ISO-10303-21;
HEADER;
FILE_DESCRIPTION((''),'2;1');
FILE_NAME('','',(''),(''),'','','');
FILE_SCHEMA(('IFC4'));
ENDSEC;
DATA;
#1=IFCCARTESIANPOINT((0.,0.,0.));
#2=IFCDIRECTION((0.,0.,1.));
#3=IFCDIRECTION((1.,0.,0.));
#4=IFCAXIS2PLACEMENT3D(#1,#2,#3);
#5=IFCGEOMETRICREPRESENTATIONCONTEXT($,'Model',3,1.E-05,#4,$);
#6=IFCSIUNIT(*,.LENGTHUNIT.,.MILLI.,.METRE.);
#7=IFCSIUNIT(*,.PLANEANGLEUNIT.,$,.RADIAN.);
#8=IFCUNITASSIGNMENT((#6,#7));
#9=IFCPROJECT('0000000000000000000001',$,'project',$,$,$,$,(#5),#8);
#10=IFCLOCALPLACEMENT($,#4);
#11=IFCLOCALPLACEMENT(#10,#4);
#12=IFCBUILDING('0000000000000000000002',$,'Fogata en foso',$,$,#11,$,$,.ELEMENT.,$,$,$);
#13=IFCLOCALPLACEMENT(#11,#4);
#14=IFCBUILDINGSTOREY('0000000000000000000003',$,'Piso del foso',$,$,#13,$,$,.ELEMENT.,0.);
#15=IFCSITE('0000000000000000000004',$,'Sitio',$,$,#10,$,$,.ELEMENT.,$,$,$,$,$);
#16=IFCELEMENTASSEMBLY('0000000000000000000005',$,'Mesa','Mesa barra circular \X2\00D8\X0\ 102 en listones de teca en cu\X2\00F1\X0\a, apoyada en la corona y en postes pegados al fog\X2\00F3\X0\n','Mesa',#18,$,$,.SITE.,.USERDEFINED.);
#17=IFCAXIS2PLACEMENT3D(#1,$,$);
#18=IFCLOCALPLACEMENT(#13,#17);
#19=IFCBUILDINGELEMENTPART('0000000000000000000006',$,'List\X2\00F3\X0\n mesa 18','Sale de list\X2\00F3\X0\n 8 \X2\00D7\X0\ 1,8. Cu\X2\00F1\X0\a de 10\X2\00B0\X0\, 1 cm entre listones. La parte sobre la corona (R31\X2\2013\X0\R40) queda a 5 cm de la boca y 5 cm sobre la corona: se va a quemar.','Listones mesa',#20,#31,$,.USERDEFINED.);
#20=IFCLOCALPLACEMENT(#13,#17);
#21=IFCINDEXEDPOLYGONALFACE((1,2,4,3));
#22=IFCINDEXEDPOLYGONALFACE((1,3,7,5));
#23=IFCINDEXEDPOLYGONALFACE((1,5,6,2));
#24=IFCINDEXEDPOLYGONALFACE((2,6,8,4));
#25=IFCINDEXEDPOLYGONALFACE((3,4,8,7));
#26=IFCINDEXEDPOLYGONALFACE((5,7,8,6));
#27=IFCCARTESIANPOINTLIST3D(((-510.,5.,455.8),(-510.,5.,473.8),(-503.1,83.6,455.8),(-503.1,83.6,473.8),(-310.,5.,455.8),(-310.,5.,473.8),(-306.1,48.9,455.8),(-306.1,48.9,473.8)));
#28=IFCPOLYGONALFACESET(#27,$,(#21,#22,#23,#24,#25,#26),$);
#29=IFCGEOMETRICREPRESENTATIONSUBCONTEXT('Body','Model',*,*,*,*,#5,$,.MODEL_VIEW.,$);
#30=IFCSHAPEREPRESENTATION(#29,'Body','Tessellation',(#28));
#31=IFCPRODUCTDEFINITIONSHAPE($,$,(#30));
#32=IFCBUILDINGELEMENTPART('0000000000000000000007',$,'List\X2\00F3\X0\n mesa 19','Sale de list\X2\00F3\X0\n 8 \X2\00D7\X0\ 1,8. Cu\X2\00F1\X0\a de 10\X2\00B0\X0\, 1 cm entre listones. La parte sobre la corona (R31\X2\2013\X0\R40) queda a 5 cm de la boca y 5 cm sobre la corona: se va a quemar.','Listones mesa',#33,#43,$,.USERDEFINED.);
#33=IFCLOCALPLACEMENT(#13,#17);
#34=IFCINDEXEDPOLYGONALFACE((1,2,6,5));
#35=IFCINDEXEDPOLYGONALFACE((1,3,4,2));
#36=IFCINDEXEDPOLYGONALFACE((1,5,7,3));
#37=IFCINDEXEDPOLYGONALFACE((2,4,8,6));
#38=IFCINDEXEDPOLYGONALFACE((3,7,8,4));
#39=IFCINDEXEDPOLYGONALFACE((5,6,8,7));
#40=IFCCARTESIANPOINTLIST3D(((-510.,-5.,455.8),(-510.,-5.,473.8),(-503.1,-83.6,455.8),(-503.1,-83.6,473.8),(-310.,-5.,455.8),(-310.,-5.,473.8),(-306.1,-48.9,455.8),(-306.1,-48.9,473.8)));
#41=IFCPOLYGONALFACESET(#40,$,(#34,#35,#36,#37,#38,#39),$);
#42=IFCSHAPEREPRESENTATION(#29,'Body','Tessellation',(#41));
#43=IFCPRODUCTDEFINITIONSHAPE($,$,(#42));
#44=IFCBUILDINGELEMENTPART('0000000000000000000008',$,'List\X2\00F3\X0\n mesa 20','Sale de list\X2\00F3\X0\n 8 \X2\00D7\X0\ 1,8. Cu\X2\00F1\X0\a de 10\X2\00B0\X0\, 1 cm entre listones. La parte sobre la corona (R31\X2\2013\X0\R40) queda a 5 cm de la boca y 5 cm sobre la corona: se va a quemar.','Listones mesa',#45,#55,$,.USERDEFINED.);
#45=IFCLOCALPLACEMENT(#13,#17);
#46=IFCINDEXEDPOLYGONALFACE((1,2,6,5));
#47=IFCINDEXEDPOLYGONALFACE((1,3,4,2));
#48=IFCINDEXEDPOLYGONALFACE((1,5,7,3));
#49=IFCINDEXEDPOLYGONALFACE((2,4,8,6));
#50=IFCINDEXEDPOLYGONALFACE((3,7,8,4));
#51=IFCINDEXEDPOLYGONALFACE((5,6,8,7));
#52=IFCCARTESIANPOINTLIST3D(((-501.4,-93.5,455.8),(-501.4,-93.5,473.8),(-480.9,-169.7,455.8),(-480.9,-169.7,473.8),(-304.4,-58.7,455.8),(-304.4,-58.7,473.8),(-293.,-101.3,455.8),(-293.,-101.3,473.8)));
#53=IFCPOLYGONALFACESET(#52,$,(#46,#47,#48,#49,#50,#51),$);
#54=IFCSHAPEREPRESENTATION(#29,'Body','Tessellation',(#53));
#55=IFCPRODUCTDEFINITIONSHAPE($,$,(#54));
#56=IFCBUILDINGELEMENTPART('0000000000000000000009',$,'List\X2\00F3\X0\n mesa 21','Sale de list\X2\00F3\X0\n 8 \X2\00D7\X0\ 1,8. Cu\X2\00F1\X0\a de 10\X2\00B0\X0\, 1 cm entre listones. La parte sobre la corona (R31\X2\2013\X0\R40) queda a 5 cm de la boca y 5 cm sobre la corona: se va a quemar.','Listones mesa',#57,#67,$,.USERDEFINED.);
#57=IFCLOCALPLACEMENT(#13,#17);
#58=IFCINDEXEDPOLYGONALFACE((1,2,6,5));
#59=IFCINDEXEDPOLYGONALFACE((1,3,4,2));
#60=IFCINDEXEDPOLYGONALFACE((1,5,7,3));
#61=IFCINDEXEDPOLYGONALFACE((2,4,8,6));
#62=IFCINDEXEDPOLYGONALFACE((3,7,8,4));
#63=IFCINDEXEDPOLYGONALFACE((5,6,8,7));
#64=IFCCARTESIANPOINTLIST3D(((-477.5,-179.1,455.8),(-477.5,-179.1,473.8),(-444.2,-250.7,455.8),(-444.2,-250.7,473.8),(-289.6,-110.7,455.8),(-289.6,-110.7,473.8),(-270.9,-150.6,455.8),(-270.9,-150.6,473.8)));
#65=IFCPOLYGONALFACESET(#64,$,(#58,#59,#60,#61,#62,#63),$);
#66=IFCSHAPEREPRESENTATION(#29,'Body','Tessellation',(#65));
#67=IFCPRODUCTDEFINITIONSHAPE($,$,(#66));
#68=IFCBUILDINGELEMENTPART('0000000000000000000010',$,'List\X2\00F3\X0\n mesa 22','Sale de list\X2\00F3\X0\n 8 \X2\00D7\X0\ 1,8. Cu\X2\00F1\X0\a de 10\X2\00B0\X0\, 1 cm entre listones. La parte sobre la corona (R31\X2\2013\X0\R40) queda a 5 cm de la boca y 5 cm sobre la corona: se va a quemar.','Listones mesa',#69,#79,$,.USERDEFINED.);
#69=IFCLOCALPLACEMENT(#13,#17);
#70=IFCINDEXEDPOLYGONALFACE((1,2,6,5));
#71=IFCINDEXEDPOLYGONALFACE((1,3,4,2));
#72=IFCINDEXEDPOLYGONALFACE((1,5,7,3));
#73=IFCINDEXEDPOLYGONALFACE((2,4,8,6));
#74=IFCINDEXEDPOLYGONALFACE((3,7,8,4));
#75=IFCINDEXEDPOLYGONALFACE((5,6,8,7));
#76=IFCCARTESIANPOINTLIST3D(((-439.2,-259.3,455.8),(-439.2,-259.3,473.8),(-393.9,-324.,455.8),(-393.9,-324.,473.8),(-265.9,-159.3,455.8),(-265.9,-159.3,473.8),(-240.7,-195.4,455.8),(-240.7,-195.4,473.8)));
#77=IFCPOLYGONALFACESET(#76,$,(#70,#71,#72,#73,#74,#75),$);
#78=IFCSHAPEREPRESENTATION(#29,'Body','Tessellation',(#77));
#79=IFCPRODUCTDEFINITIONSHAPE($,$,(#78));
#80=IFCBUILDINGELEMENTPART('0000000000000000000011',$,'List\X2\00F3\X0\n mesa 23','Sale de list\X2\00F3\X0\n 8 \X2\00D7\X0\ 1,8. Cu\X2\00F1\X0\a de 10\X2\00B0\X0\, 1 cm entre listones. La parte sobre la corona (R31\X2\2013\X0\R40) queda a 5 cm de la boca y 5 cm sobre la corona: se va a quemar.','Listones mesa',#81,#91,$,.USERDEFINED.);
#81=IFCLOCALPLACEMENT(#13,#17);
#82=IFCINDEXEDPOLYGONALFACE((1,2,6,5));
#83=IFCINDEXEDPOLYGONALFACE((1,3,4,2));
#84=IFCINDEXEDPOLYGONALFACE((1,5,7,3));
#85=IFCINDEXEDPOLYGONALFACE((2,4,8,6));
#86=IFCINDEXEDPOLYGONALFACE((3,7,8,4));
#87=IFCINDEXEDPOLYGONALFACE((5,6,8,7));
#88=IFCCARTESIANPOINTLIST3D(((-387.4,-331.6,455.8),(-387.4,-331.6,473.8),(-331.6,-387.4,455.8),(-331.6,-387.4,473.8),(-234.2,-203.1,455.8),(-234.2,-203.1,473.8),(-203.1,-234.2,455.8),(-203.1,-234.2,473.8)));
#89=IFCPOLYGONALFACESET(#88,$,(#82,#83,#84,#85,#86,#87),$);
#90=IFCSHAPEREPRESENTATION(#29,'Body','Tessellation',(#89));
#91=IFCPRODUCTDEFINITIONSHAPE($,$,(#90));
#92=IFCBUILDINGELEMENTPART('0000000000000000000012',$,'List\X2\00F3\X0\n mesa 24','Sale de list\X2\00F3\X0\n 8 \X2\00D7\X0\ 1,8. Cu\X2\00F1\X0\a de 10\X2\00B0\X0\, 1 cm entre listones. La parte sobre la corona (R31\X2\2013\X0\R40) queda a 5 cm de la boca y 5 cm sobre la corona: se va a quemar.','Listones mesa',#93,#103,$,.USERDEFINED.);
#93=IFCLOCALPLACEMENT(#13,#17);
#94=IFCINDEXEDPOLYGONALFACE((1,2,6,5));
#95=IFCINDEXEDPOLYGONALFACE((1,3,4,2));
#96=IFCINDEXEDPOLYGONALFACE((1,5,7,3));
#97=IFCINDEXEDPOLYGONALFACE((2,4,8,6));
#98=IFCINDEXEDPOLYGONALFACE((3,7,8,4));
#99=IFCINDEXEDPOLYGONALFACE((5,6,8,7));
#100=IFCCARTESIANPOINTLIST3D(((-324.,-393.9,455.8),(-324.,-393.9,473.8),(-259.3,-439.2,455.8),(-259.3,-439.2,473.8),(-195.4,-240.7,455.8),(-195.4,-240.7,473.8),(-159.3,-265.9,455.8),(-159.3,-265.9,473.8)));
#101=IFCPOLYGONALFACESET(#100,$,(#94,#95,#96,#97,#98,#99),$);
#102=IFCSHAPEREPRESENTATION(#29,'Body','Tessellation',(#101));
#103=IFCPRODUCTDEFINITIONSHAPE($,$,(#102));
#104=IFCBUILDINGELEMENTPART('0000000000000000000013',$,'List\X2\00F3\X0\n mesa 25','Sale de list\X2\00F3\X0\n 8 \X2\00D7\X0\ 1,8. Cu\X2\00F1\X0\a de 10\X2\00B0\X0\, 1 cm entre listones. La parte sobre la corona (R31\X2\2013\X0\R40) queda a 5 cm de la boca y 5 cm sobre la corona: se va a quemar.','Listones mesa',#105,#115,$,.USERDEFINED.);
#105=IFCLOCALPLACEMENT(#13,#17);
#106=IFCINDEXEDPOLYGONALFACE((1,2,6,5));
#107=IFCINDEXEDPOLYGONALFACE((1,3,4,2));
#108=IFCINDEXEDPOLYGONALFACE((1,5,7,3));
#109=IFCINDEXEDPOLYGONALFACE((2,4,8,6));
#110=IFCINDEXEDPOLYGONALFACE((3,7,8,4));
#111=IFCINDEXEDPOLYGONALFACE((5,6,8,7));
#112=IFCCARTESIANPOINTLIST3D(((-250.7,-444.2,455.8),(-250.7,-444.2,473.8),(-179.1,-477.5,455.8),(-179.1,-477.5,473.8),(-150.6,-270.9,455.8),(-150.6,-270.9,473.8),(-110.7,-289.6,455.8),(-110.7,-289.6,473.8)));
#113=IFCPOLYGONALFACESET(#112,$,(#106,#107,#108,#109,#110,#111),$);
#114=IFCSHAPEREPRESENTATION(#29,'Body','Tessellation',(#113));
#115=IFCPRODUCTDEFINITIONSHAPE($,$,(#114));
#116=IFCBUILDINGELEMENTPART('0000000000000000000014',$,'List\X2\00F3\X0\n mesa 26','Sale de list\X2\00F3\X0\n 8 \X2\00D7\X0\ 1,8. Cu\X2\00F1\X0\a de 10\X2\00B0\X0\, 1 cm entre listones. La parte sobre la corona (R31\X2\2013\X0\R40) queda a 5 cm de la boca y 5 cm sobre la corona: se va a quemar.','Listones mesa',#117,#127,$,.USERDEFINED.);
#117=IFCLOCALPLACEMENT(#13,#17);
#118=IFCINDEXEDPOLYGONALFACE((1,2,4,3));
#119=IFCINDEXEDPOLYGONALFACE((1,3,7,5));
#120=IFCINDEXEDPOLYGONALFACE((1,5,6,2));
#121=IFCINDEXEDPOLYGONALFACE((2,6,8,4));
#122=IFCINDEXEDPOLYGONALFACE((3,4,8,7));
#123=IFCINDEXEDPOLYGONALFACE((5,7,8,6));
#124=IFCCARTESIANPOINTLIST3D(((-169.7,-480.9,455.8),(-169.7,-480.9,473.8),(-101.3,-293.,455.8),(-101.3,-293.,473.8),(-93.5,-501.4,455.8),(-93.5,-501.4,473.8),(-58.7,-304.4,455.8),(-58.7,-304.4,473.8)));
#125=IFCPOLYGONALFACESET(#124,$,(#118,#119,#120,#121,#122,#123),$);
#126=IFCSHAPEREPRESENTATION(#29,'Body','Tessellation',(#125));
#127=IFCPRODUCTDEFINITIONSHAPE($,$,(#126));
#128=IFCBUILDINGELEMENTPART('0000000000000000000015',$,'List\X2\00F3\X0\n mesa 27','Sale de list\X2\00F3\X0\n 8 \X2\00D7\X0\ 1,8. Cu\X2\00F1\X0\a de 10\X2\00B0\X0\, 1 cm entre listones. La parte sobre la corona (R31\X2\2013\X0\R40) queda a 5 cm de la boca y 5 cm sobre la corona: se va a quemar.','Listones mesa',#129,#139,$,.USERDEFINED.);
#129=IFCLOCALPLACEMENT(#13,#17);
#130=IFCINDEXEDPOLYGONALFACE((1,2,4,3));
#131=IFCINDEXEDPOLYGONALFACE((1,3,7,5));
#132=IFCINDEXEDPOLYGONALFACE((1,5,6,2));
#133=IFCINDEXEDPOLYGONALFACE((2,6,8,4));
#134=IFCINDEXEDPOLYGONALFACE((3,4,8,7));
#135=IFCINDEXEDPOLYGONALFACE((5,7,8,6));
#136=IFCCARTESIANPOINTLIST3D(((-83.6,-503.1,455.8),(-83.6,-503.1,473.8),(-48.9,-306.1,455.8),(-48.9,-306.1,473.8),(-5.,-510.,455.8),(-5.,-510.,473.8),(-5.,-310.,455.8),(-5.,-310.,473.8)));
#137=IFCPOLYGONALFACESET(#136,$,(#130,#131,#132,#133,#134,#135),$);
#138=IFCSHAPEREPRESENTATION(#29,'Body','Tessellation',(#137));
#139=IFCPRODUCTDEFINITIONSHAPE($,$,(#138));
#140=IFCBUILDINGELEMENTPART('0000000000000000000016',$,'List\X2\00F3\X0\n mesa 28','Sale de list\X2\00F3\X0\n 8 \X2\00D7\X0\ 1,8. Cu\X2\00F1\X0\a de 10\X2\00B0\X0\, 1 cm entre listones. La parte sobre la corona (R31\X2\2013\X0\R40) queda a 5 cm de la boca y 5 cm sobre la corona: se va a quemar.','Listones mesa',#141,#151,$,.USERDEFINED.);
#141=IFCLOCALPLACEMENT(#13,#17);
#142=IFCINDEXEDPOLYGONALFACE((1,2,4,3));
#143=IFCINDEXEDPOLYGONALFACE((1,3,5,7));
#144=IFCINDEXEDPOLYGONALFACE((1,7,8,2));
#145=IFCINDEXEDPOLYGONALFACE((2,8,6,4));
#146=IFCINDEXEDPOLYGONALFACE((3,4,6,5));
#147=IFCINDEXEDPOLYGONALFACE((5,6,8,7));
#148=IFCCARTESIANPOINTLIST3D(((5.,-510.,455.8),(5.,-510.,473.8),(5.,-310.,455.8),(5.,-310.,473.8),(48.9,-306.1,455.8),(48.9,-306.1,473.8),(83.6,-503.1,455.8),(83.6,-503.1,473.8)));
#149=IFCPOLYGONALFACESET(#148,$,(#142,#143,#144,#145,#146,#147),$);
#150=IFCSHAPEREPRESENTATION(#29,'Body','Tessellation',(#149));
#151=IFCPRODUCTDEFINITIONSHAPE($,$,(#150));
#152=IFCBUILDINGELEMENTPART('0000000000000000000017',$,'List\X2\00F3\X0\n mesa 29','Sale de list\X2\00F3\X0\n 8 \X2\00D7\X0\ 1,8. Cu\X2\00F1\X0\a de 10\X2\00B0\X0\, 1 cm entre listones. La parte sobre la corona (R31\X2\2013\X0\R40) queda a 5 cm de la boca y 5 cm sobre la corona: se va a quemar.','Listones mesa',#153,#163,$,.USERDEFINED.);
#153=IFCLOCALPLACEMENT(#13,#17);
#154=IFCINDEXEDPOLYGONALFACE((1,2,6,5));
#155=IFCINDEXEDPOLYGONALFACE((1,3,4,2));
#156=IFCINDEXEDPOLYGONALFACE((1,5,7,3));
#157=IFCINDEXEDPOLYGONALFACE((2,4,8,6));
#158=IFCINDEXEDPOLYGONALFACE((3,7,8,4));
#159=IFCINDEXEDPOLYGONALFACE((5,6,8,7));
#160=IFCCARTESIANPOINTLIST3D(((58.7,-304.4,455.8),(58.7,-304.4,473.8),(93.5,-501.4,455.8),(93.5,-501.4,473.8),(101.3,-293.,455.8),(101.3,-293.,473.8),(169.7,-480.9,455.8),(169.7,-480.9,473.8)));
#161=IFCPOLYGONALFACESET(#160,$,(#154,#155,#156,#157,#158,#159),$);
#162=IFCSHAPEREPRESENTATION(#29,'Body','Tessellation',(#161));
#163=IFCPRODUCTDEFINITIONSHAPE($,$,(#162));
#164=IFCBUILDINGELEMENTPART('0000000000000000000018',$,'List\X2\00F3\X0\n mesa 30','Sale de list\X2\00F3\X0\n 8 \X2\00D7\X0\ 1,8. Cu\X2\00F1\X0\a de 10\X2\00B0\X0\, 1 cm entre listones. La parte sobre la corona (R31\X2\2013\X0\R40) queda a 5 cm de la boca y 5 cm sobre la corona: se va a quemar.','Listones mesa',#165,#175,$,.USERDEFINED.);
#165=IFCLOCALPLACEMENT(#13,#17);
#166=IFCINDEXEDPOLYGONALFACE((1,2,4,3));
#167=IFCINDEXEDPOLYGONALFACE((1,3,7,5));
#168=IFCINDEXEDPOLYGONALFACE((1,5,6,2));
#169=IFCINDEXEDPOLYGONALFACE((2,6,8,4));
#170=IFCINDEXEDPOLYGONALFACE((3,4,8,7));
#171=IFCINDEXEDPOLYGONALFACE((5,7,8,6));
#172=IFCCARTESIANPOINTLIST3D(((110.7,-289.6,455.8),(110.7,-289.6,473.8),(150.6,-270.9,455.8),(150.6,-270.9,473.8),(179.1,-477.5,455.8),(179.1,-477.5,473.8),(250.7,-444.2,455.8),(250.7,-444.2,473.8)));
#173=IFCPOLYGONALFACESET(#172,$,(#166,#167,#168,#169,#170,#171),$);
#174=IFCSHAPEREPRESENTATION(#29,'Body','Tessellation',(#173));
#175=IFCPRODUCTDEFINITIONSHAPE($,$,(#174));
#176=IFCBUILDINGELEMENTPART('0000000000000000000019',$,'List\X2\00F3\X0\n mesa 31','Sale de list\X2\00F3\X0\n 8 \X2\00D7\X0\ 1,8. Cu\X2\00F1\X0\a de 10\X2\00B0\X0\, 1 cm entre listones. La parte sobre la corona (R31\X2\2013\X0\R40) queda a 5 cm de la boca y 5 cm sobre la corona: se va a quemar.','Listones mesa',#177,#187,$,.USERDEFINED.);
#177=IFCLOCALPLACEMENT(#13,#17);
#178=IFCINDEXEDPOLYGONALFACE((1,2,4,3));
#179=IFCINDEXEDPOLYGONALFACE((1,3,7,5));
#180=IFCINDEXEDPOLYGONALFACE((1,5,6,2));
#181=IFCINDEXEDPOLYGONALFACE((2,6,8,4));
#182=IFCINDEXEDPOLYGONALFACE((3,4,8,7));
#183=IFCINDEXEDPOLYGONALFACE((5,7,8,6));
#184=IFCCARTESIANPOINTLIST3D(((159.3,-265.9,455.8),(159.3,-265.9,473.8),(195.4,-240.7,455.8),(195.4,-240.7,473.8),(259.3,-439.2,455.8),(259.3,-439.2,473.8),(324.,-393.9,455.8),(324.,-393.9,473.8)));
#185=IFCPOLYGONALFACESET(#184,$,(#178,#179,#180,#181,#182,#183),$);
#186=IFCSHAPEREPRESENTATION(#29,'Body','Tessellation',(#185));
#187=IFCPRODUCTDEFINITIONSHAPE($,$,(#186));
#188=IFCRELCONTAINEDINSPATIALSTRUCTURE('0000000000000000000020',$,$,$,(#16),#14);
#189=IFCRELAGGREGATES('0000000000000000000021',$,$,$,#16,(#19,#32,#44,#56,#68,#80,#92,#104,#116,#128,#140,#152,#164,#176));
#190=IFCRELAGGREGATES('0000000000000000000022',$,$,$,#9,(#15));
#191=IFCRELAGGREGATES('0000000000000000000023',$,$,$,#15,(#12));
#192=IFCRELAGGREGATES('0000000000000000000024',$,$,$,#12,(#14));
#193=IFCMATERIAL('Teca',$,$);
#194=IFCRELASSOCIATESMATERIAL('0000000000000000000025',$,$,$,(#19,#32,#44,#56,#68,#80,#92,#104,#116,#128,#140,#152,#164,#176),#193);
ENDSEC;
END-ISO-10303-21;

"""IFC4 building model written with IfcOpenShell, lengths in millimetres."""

from ifc_helpers import new_model, si_unit, frame, origin_with_axes, place, context, subcontext, project, spatial, polyline, outline, extrude, material, element, aggregate, save


model = new_model("IFC4")

# Units and contexts
model_context = context("Model", 3, precision=1e-05, world=origin_with_axes())
body_context = subcontext(model_context, "Body", "Model", "MODEL_VIEW")
ifc_project = project(units=[si_unit("LENGTHUNIT", "METRE", prefix="MILLI"), si_unit("PLANEANGLEUNIT", "RADIAN")], contexts=[model_context])

# Site, building, storey
site_placement = place(None, origin_with_axes())
site = spatial("IfcSite", under=ifc_project, at=site_placement, Name="Sitio", CompositionType="ELEMENT")
building_placement = place(site_placement, origin_with_axes())
building = spatial("IfcBuilding", under=site, at=building_placement, Name="Fogata en foso", CompositionType="ELEMENT")
storey_placement = place(building_placement, origin_with_axes())
storey = spatial("IfcBuildingStorey", under=building, at=storey_placement, Name="Piso del foso", CompositionType="ELEMENT", Elevation=0.0)

# Element assembly, building element parts
ifc_material = material(Name="Teca")
assembly_1_placement = place(storey_placement, origin_with_axes())
assembly_1 = element("IfcElementAssembly", 1, at=assembly_1_placement, inside=storey, Name="Mesa", Description="Mesa barra circular Ø 102 en listones de teca en cuña, apoyada en la corona y en postes pegados al fogón", ObjectType="Mesa", AssemblyPlace="SITE", PredefinedType="USERDEFINED")
building_element_part_1_placement = place(storey_placement, frame((0.0, 0.0, 455.8), z_axis=(0.0, 0.0, 1.0), x_axis=(1.0, 0.0, 0.0)))
building_element_part_1 = element("IfcBuildingElementPart", 2, at=building_element_part_1_placement, material=ifc_material, Name="Listón mesa 18", Description="Sale de listón 8 × 1,8. Cuña de 10°, 1 cm entre listones. La parte sobre la corona (R31–R40) queda a 5 cm de la boca y 5 cm sobre la corona: se va a quemar.", ObjectType="Listones mesa", PredefinedType="USERDEFINED", context=body_context, shape_type="SweptSolid", body=[
    extrude(outline(polyline([(-306.1, 48.9), (-503.1, 83.6), (-510.0, 5.0), (-310.0, 5.0), (-306.1, 48.9)])), origin_with_axes(), (0.0, 0.0, 1.0), 18.0),
])
building_element_part_2_placement = place(storey_placement, frame((0.0, 0.0, 455.8), z_axis=(0.0, 0.0, 1.0), x_axis=(1.0, 0.0, 0.0)))
building_element_part_2 = element("IfcBuildingElementPart", 3, at=building_element_part_2_placement, material=ifc_material, Name="Listón mesa 19", Description="Sale de listón 8 × 1,8. Cuña de 10°, 1 cm entre listones. La parte sobre la corona (R31–R40) queda a 5 cm de la boca y 5 cm sobre la corona: se va a quemar.", ObjectType="Listones mesa", PredefinedType="USERDEFINED", context=body_context, shape_type="SweptSolid", body=[
    extrude(outline(polyline([(-310.0, -5.0), (-510.0, -5.0), (-503.1, -83.6), (-306.1, -48.9), (-310.0, -5.0)])), origin_with_axes(), (0.0, 0.0, 1.0), 18.0),
])
building_element_part_3_placement = place(storey_placement, frame((0.0, 0.0, 455.8), z_axis=(0.0, 0.0, 1.0), x_axis=(1.0, 0.0, 0.0)))
building_element_part_3 = element("IfcBuildingElementPart", 4, at=building_element_part_3_placement, material=ifc_material, Name="Listón mesa 20", Description="Sale de listón 8 × 1,8. Cuña de 10°, 1 cm entre listones. La parte sobre la corona (R31–R40) queda a 5 cm de la boca y 5 cm sobre la corona: se va a quemar.", ObjectType="Listones mesa", PredefinedType="USERDEFINED", context=body_context, shape_type="SweptSolid", body=[
    extrude(outline(polyline([(-304.4, -58.7), (-501.4, -93.5), (-480.9, -169.7), (-293.0, -101.3), (-304.4, -58.7)])), origin_with_axes(), (0.0, 0.0, 1.0), 18.0),
])
building_element_part_4_placement = place(storey_placement, frame((0.0, 0.0, 455.8), z_axis=(0.0, 0.0, 1.0), x_axis=(1.0, 0.0, 0.0)))
building_element_part_4 = element("IfcBuildingElementPart", 5, at=building_element_part_4_placement, material=ifc_material, Name="Listón mesa 21", Description="Sale de listón 8 × 1,8. Cuña de 10°, 1 cm entre listones. La parte sobre la corona (R31–R40) queda a 5 cm de la boca y 5 cm sobre la corona: se va a quemar.", ObjectType="Listones mesa", PredefinedType="USERDEFINED", context=body_context, shape_type="SweptSolid", body=[
    extrude(outline(polyline([(-289.6, -110.7), (-477.5, -179.1), (-444.2, -250.7), (-270.9, -150.7), (-289.6, -110.7)])), origin_with_axes(), (0.0, 0.0, 1.0), 18.0),
])
building_element_part_5_placement = place(storey_placement, frame((0.0, 0.0, 455.8), z_axis=(0.0, 0.0, 1.0), x_axis=(1.0, 0.0, 0.0)))
building_element_part_5 = element("IfcBuildingElementPart", 6, at=building_element_part_5_placement, material=ifc_material, Name="Listón mesa 22", Description="Sale de listón 8 × 1,8. Cuña de 10°, 1 cm entre listones. La parte sobre la corona (R31–R40) queda a 5 cm de la boca y 5 cm sobre la corona: se va a quemar.", ObjectType="Listones mesa", PredefinedType="USERDEFINED", context=body_context, shape_type="SweptSolid", body=[
    extrude(outline(polyline([(-265.9, -159.3), (-439.2, -259.3), (-393.9, -324.0), (-240.7, -195.4), (-265.9, -159.3)])), origin_with_axes(), (0.0, 0.0, 1.0), 18.0),
])
building_element_part_6_placement = place(storey_placement, frame((0.0, 0.0, 455.8), z_axis=(0.0, 0.0, 1.0), x_axis=(1.0, 0.0, 0.0)))
building_element_part_6 = element("IfcBuildingElementPart", 7, at=building_element_part_6_placement, material=ifc_material, Name="Listón mesa 23", Description="Sale de listón 8 × 1,8. Cuña de 10°, 1 cm entre listones. La parte sobre la corona (R31–R40) queda a 5 cm de la boca y 5 cm sobre la corona: se va a quemar.", ObjectType="Listones mesa", PredefinedType="USERDEFINED", context=body_context, shape_type="SweptSolid", body=[
    extrude(outline(polyline([(-234.2, -203.1), (-387.4, -331.6), (-331.6, -387.4), (-203.1, -234.2), (-234.2, -203.1)])), origin_with_axes(), (0.0, 0.0, 1.0), 18.0),
])
building_element_part_7_placement = place(storey_placement, frame((0.0, 0.0, 455.8), z_axis=(0.0, 0.0, 1.0), x_axis=(1.0, 0.0, 0.0)))
building_element_part_7 = element("IfcBuildingElementPart", 8, at=building_element_part_7_placement, material=ifc_material, Name="Listón mesa 24", Description="Sale de listón 8 × 1,8. Cuña de 10°, 1 cm entre listones. La parte sobre la corona (R31–R40) queda a 5 cm de la boca y 5 cm sobre la corona: se va a quemar.", ObjectType="Listones mesa", PredefinedType="USERDEFINED", context=body_context, shape_type="SweptSolid", body=[
    extrude(outline(polyline([(-195.4, -240.7), (-324.0, -393.9), (-259.3, -439.2), (-159.3, -265.9), (-195.4, -240.7)])), origin_with_axes(), (0.0, 0.0, 1.0), 18.0),
])
building_element_part_8_placement = place(storey_placement, frame((0.0, 0.0, 455.8), z_axis=(0.0, 0.0, 1.0), x_axis=(1.0, 0.0, 0.0)))
building_element_part_8 = element("IfcBuildingElementPart", 9, at=building_element_part_8_placement, material=ifc_material, Name="Listón mesa 25", Description="Sale de listón 8 × 1,8. Cuña de 10°, 1 cm entre listones. La parte sobre la corona (R31–R40) queda a 5 cm de la boca y 5 cm sobre la corona: se va a quemar.", ObjectType="Listones mesa", PredefinedType="USERDEFINED", context=body_context, shape_type="SweptSolid", body=[
    extrude(outline(polyline([(-150.7, -270.9), (-250.7, -444.2), (-179.1, -477.5), (-110.7, -289.6), (-150.7, -270.9)])), origin_with_axes(), (0.0, 0.0, 1.0), 18.0),
])
building_element_part_9_placement = place(storey_placement, frame((0.0, 0.0, 455.8), z_axis=(0.0, 0.0, 1.0), x_axis=(1.0, 0.0, 0.0)))
building_element_part_9 = element("IfcBuildingElementPart", 10, at=building_element_part_9_placement, material=ifc_material, Name="Listón mesa 26", Description="Sale de listón 8 × 1,8. Cuña de 10°, 1 cm entre listones. La parte sobre la corona (R31–R40) queda a 5 cm de la boca y 5 cm sobre la corona: se va a quemar.", ObjectType="Listones mesa", PredefinedType="USERDEFINED", context=body_context, shape_type="SweptSolid", body=[
    extrude(outline(polyline([(-101.3, -293.0), (-169.7, -480.9), (-93.5, -501.4), (-58.7, -304.4), (-101.3, -293.0)])), origin_with_axes(), (0.0, 0.0, 1.0), 18.0),
])
building_element_part_10_placement = place(storey_placement, frame((0.0, 0.0, 455.8), z_axis=(0.0, 0.0, 1.0), x_axis=(1.0, 0.0, 0.0)))
building_element_part_10 = element("IfcBuildingElementPart", 11, at=building_element_part_10_placement, material=ifc_material, Name="Listón mesa 27", Description="Sale de listón 8 × 1,8. Cuña de 10°, 1 cm entre listones. La parte sobre la corona (R31–R40) queda a 5 cm de la boca y 5 cm sobre la corona: se va a quemar.", ObjectType="Listones mesa", PredefinedType="USERDEFINED", context=body_context, shape_type="SweptSolid", body=[
    extrude(outline(polyline([(-48.9, -306.1), (-83.6, -503.1), (-5.0, -510.0), (-5.0, -310.0), (-48.9, -306.1)])), origin_with_axes(), (0.0, 0.0, 1.0), 18.0),
])
building_element_part_11_placement = place(storey_placement, frame((0.0, 0.0, 455.8), z_axis=(0.0, 0.0, 1.0), x_axis=(1.0, 0.0, 0.0)))
building_element_part_11 = element("IfcBuildingElementPart", 12, at=building_element_part_11_placement, material=ifc_material, Name="Listón mesa 28", Description="Sale de listón 8 × 1,8. Cuña de 10°, 1 cm entre listones. La parte sobre la corona (R31–R40) queda a 5 cm de la boca y 5 cm sobre la corona: se va a quemar.", ObjectType="Listones mesa", PredefinedType="USERDEFINED", context=body_context, shape_type="SweptSolid", body=[
    extrude(outline(polyline([(5.0, -310.0), (5.0, -510.0), (83.6, -503.1), (48.9, -306.1), (5.0, -310.0)])), origin_with_axes(), (0.0, 0.0, 1.0), 18.0),
])
building_element_part_12_placement = place(storey_placement, frame((0.0, 0.0, 455.8), z_axis=(0.0, 0.0, 1.0), x_axis=(1.0, 0.0, 0.0)))
building_element_part_12 = element("IfcBuildingElementPart", 13, at=building_element_part_12_placement, material=ifc_material, Name="Listón mesa 29", Description="Sale de listón 8 × 1,8. Cuña de 10°, 1 cm entre listones. La parte sobre la corona (R31–R40) queda a 5 cm de la boca y 5 cm sobre la corona: se va a quemar.", ObjectType="Listones mesa", PredefinedType="USERDEFINED", context=body_context, shape_type="SweptSolid", body=[
    extrude(outline(polyline([(58.7, -304.4), (93.5, -501.4), (169.7, -480.9), (101.3, -293.0), (58.7, -304.4)])), origin_with_axes(), (0.0, 0.0, 1.0), 18.0),
])
building_element_part_13_placement = place(storey_placement, frame((0.0, 0.0, 455.8), z_axis=(0.0, 0.0, 1.0), x_axis=(1.0, 0.0, 0.0)))
building_element_part_13 = element("IfcBuildingElementPart", 14, at=building_element_part_13_placement, material=ifc_material, Name="Listón mesa 30", Description="Sale de listón 8 × 1,8. Cuña de 10°, 1 cm entre listones. La parte sobre la corona (R31–R40) queda a 5 cm de la boca y 5 cm sobre la corona: se va a quemar.", ObjectType="Listones mesa", PredefinedType="USERDEFINED", context=body_context, shape_type="SweptSolid", body=[
    extrude(outline(polyline([(110.7, -289.6), (179.1, -477.5), (250.7, -444.2), (150.7, -270.9), (110.7, -289.6)])), origin_with_axes(), (0.0, 0.0, 1.0), 18.0),
])
building_element_part_14_placement = place(storey_placement, frame((0.0, 0.0, 455.8), z_axis=(0.0, 0.0, 1.0), x_axis=(1.0, 0.0, 0.0)))
building_element_part_14 = element("IfcBuildingElementPart", 15, at=building_element_part_14_placement, material=ifc_material, Name="Listón mesa 31", Description="Sale de listón 8 × 1,8. Cuña de 10°, 1 cm entre listones. La parte sobre la corona (R31–R40) queda a 5 cm de la boca y 5 cm sobre la corona: se va a quemar.", ObjectType="Listones mesa", PredefinedType="USERDEFINED", context=body_context, shape_type="SweptSolid", body=[
    extrude(outline(polyline([(159.3, -265.9), (259.3, -439.2), (324.0, -393.9), (195.4, -240.7), (159.3, -265.9)])), origin_with_axes(), (0.0, 0.0, 1.0), 18.0),
])
aggregate(assembly_1, [building_element_part_1, building_element_part_2, building_element_part_3, building_element_part_4, building_element_part_5, building_element_part_6, building_element_part_7, building_element_part_8, building_element_part_9, building_element_part_10, building_element_part_11, building_element_part_12, building_element_part_13, building_element_part_14])

save(model, "model.ifc")
